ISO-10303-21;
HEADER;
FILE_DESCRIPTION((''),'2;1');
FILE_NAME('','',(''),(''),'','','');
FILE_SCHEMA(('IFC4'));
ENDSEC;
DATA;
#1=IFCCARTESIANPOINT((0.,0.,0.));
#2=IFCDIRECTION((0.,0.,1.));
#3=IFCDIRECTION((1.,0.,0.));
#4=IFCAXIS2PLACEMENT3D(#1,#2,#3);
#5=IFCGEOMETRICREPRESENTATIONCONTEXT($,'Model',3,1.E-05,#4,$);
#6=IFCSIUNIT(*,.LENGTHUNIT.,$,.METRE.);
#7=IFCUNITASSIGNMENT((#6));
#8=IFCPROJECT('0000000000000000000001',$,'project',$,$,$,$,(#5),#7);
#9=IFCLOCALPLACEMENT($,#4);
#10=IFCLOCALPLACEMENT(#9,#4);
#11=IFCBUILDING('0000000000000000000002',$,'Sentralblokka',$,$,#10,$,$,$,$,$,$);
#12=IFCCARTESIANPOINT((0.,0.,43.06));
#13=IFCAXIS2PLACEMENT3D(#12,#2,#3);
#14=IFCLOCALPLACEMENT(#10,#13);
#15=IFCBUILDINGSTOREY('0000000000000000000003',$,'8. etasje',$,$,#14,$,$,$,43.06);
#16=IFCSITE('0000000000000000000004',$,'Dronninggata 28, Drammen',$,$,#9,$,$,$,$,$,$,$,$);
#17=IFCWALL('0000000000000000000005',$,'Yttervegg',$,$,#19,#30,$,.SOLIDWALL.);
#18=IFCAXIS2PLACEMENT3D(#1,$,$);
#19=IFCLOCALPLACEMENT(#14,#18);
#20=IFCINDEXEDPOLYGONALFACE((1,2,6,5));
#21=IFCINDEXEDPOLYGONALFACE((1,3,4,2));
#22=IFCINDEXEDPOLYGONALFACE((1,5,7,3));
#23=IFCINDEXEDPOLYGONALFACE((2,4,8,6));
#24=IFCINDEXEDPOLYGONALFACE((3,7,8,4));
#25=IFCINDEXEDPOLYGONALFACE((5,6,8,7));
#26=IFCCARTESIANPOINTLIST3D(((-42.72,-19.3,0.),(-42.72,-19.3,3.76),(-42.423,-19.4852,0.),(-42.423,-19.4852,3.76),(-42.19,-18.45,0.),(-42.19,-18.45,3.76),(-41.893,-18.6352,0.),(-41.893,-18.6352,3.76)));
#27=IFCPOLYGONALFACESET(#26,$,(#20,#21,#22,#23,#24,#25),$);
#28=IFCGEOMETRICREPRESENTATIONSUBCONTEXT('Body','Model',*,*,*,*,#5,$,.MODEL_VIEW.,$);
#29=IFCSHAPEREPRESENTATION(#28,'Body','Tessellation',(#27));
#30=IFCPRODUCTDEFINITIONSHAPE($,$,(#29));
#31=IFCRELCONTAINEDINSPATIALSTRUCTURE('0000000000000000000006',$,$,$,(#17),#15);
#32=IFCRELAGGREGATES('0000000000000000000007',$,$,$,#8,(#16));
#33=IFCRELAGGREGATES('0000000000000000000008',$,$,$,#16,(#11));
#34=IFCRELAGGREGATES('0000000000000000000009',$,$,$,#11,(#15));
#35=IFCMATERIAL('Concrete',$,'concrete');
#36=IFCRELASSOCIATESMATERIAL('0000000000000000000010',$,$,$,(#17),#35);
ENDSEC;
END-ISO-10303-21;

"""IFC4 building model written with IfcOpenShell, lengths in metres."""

from ifc_helpers import new_model, si_unit, frame, origin_with_axes, place, context, subcontext, project, spatial, polyline, outline, extrude, material, element, save


model = new_model("IFC4")

# Units and contexts
model_context = context("Model", 3, precision=1e-05, world=origin_with_axes())
body_context = subcontext(model_context, "Body", "Model", "MODEL_VIEW")
ifc_project = project(units=[si_unit("LENGTHUNIT", "METRE")], contexts=[model_context])

# Site, building, storey
site_placement = place(None, origin_with_axes())
site = spatial("IfcSite", under=ifc_project, at=site_placement, Name="Dronninggata 28, Drammen")
building_placement = place(site_placement, origin_with_axes())
building = spatial("IfcBuilding", under=site, at=building_placement, Name="Sentralblokka")
storey_placement = place(building_placement, frame((0.0, 0.0, 43.06), z_axis=(0.0, 0.0, 1.0), x_axis=(1.0, 0.0, 0.0)))
storey = spatial("IfcBuildingStorey", under=building, at=storey_placement, Name="8. etasje", Elevation=43.06)

# Shared definitions
ifc_material_1 = material(Name="Concrete", Category="concrete")

# Wall
wall_1_placement = place(storey_placement, frame((0.0, 0.0, -43.06), z_axis=(0.0, 0.0, 1.0), x_axis=(1.0, 0.0, 0.0)))
element("IfcWall", 1, at=wall_1_placement, inside=storey, material=ifc_material_1, Name="Yttervegg", PredefinedType="SOLIDWALL", context=body_context, shape_type="SweptSolid", body=[
    extrude(outline(polyline([(-42.19, -18.45), (-42.72, -19.3), (-42.423, -19.4852), (-41.893, -18.6352), (-42.19, -18.45)])), frame((0.0, 0.0, 43.06)), (0.0, 0.0, 1.0), 3.76),
])

save(model, "model.ifc")
